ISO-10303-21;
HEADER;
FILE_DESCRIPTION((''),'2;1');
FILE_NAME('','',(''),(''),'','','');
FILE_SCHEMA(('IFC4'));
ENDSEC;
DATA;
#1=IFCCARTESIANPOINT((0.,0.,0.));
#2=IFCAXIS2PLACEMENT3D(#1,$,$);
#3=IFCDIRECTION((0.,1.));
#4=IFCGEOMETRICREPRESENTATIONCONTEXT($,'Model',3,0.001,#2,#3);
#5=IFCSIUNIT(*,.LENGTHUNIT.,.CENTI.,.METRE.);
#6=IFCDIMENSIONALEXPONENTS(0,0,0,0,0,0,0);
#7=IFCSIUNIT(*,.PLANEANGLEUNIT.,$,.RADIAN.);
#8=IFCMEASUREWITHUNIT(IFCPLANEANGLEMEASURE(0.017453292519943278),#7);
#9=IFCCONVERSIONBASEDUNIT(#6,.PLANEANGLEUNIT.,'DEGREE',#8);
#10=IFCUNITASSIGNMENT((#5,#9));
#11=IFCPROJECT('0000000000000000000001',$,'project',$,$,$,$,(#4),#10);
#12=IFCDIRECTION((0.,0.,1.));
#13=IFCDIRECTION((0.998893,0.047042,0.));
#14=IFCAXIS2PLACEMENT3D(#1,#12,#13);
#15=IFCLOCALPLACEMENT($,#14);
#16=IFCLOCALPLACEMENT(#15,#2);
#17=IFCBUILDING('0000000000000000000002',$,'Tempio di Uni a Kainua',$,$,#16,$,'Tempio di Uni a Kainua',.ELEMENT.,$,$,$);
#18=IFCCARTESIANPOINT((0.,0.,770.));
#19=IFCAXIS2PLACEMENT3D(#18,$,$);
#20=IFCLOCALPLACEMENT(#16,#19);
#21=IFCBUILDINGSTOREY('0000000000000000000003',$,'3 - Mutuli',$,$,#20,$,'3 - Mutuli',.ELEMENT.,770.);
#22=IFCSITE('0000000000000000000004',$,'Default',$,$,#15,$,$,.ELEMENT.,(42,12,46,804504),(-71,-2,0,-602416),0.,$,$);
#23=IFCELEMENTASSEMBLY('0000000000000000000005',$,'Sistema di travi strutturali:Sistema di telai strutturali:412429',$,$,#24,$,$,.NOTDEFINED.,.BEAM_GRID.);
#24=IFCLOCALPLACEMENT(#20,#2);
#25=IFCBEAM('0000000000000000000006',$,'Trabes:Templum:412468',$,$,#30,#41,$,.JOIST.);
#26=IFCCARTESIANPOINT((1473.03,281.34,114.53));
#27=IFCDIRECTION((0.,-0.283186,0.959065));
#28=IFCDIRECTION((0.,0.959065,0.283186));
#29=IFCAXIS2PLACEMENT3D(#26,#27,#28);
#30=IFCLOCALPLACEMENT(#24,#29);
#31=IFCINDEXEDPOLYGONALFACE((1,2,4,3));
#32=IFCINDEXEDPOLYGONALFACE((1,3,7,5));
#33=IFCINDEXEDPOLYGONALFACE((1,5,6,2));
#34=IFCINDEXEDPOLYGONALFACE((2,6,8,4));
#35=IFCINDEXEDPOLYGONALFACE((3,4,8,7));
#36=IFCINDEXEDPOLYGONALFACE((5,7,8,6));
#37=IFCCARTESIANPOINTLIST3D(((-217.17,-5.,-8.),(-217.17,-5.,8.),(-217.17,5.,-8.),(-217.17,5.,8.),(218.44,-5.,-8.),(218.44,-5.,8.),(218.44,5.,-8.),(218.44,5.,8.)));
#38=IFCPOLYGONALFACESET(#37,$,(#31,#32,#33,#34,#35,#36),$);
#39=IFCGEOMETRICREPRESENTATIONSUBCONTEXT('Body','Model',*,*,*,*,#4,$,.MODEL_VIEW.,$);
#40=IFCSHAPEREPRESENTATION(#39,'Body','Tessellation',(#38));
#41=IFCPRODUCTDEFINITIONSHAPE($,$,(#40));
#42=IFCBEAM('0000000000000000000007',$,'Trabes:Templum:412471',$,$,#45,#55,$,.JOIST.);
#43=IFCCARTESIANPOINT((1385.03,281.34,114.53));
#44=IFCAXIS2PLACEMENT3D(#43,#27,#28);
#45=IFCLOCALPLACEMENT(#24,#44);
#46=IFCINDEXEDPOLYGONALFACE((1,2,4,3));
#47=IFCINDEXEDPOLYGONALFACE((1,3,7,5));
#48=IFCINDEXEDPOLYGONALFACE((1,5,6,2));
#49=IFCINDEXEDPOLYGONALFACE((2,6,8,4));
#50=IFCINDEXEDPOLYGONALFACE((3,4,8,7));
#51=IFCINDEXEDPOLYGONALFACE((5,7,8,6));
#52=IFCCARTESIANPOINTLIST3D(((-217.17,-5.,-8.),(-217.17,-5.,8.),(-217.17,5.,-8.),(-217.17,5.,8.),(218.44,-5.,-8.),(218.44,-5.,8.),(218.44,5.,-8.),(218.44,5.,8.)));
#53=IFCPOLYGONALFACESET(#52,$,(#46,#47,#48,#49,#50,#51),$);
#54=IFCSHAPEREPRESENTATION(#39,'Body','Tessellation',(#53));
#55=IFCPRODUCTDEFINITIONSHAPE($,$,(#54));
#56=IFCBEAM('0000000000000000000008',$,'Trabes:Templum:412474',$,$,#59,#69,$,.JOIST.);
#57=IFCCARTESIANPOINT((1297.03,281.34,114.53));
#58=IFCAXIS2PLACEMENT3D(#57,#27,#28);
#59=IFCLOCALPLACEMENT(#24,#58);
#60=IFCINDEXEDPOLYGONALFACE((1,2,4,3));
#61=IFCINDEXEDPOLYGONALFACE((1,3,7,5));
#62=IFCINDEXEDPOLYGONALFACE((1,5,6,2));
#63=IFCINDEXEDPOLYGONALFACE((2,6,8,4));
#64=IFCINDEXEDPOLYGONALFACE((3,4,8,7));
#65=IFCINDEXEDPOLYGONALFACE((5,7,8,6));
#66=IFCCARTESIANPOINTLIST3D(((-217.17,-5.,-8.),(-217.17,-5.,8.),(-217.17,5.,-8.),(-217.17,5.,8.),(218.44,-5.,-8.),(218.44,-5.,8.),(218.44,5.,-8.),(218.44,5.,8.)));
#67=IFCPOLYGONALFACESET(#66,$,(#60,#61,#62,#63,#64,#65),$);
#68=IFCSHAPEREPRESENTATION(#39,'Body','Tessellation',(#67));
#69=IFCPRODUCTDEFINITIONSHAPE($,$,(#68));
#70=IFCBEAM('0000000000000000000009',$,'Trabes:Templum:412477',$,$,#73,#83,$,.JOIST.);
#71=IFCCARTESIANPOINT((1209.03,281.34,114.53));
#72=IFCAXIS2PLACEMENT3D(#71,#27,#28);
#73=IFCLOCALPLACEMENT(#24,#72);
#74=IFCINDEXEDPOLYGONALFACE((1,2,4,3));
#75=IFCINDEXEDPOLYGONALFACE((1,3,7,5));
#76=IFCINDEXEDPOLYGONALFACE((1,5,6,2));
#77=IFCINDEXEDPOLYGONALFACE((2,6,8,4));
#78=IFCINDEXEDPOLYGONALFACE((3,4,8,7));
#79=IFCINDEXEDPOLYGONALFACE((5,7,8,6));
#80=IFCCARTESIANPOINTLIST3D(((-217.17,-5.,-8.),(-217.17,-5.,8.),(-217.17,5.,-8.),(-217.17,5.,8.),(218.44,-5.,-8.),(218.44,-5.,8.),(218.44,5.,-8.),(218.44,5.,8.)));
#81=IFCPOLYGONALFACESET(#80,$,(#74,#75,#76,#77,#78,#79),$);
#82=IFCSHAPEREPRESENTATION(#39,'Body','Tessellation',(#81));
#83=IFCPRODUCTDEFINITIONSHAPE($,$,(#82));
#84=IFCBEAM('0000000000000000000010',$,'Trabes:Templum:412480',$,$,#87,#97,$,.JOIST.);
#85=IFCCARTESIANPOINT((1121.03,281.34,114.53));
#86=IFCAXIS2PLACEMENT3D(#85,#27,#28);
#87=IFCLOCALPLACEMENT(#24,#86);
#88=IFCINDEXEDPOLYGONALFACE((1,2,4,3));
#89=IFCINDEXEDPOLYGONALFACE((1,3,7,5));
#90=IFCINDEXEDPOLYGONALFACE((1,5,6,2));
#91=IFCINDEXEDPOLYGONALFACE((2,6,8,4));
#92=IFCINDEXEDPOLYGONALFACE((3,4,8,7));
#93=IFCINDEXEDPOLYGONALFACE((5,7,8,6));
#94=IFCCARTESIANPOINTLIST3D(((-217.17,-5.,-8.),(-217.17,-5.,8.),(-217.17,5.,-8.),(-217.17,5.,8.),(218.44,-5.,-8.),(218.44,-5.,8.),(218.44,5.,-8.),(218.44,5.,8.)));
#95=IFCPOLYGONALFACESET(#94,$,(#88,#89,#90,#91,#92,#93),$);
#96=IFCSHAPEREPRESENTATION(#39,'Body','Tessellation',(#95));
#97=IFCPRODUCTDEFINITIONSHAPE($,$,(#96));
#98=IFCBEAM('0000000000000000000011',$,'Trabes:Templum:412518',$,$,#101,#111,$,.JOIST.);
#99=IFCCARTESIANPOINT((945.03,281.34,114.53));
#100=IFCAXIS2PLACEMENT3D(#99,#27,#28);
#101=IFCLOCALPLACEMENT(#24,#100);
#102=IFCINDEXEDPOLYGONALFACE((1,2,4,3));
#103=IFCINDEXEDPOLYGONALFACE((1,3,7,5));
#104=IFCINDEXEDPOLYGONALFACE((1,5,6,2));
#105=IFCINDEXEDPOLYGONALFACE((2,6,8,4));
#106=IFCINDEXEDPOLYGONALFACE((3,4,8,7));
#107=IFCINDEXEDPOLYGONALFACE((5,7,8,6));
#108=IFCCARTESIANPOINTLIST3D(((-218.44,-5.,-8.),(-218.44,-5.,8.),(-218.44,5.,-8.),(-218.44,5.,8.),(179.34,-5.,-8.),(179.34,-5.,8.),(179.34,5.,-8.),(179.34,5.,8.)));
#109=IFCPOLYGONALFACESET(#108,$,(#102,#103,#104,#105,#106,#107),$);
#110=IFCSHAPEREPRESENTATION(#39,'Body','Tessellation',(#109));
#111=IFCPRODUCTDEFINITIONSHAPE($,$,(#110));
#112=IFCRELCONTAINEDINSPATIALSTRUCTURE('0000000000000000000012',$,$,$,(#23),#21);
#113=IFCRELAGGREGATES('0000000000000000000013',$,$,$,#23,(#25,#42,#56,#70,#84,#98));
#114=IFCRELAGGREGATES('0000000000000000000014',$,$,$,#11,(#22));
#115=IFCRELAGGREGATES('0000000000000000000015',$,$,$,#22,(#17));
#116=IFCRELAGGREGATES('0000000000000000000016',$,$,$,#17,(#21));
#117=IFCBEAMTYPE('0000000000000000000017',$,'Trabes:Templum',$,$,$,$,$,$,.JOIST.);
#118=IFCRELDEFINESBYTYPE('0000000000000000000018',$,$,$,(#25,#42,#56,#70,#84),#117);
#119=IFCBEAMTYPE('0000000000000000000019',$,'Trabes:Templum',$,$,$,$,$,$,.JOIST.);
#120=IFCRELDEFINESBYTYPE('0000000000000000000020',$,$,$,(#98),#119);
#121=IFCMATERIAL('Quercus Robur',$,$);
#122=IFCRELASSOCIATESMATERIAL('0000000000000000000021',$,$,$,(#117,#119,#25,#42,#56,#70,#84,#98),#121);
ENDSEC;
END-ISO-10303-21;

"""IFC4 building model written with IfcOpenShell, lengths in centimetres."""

from ifc_helpers import new_model, entity, si_unit, converted_unit, direction, frame, origin, origin_2d_with_axis, place, context, subcontext, project, spatial, rectangle, extrude, source, transform, mapped, material, material_profile, profile_set, profile_usage, type_object, type_shapes, element, aggregate, save


model = new_model("IFC4")

# Units and contexts
model_context = context("Model", 3, precision=0.001, world=origin(), true_north=direction((0.0, 1.0)))
body_context = subcontext(model_context, "Body", "Model", "MODEL_VIEW")
ifc_project = project(units=[si_unit("LENGTHUNIT", "METRE", prefix="CENTI"), converted_unit("PLANEANGLEUNIT", "DEGREE", entity("IfcPlaneAngleMeasure", 0.017453292519943278), si_unit("PLANEANGLEUNIT", "RADIAN"), dimensions=[0, 0, 0, 0, 0, 0, 0])], contexts=[model_context])

# Site, building, storey
site_placement = place(None, frame((0.0, 0.0, 0.0), z_axis=(0.0, 0.0, 1.0), x_axis=(0.998893, 0.047042, 0.0)))
site = spatial("IfcSite", under=ifc_project, at=site_placement, Name="Default", CompositionType="ELEMENT", RefLatitude=(42, 12, 46, 804504), RefLongitude=(-71, -2, 0, -602416), RefElevation=0.0)
building_placement = place(site_placement, origin())
building = spatial("IfcBuilding", under=site, at=building_placement, Name="Tempio di Uni a Kainua", LongName="Tempio di Uni a Kainua", CompositionType="ELEMENT")
storey_placement = place(building_placement, frame((0.0, 0.0, 770.0)))
storey = spatial("IfcBuildingStorey", under=building, at=storey_placement, Name="3 - Mutuli", LongName="3 - Mutuli", CompositionType="ELEMENT", Elevation=770.0)

# Shared definitions
ifc_material = material(Name="Quercus Robur")

# Element assembly, beams
assembly_placement = place(storey_placement, origin())
assembly = element("IfcElementAssembly", 1, at=assembly_placement, inside=storey, Name="Sistema di travi strutturali:Sistema di telai strutturali:412429", AssemblyPlace="NOTDEFINED", PredefinedType="BEAM_GRID")
ifc_material_profile_1 = material_profile(ifc_material, rectangle(XDim=2875.46, YDim=10.0, at=origin_2d_with_axis()), Name="Templum")
ifc_profile_set_1 = profile_set([ifc_material_profile_1], Name="Templum")
ifc_profile_usage_1 = profile_usage(ifc_profile_set_1, cardinal=2)
beam_type_1 = type_object("IfcBeamType", Name="Trabes:Templum", PredefinedType="JOIST", material=ifc_profile_set_1)
shared_shape_1 = source(origin(), body_context, "Body", "SweptSolid", [
    extrude(rectangle(XDim=435.61, YDim=10.0, at=origin_2d_with_axis()), frame((0.64, 0.0, -8.0)), (0.0, 0.0, 1.0), 16.0),
])
type_shapes(beam_type_1, [shared_shape_1])
beam_1_placement = place(assembly_placement, frame((1473.03, 281.34, 114.53), z_axis=(0.0, -0.283186, 0.959065), x_axis=(0.0, 0.959065, 0.283186)))
beam_1 = element("IfcBeam", 2, at=beam_1_placement, type_object=beam_type_1, material=ifc_profile_usage_1, Name="Trabes:Templum:412468", PredefinedType="JOIST", context=body_context, shape_type="MappedRepresentation", body=[
    mapped(shared_shape_1, transform((0.0, 0.0, 0.0), scale=1.0)),
])
beam_2_placement = place(assembly_placement, frame((1385.03, 281.34, 114.53), z_axis=(0.0, -0.283186, 0.959065), x_axis=(0.0, 0.959065, 0.283186)))
beam_2 = element("IfcBeam", 3, at=beam_2_placement, type_object=beam_type_1, material=ifc_profile_usage_1, Name="Trabes:Templum:412471", PredefinedType="JOIST", context=body_context, shape_type="MappedRepresentation", body=[
    mapped(shared_shape_1, transform((0.0, 0.0, 0.0), scale=1.0)),
])
beam_3_placement = place(assembly_placement, frame((1297.03, 281.34, 114.53), z_axis=(0.0, -0.283186, 0.959065), x_axis=(0.0, 0.959065, 0.283186)))
beam_3 = element("IfcBeam", 4, at=beam_3_placement, type_object=beam_type_1, material=ifc_profile_usage_1, Name="Trabes:Templum:412474", PredefinedType="JOIST", context=body_context, shape_type="MappedRepresentation", body=[
    mapped(shared_shape_1, transform((0.0, 0.0, 0.0), scale=1.0)),
])
beam_4_placement = place(assembly_placement, frame((1209.03, 281.34, 114.53), z_axis=(0.0, -0.283186, 0.959065), x_axis=(0.0, 0.959065, 0.283186)))
beam_4 = element("IfcBeam", 5, at=beam_4_placement, type_object=beam_type_1, material=ifc_profile_usage_1, Name="Trabes:Templum:412477", PredefinedType="JOIST", context=body_context, shape_type="MappedRepresentation", body=[
    mapped(shared_shape_1, transform((0.0, 0.0, 0.0), scale=1.0)),
])
beam_5_placement = place(assembly_placement, frame((1121.03, 281.34, 114.53), z_axis=(0.0, -0.283186, 0.959065), x_axis=(0.0, 0.959065, 0.283186)))
beam_5 = element("IfcBeam", 6, at=beam_5_placement, type_object=beam_type_1, material=ifc_profile_usage_1, Name="Trabes:Templum:412480", PredefinedType="JOIST", context=body_context, shape_type="MappedRepresentation", body=[
    mapped(shared_shape_1, transform((0.0, 0.0, 0.0), scale=1.0)),
])
beam_type_2 = type_object("IfcBeamType", Name="Trabes:Templum", PredefinedType="JOIST", material=ifc_profile_set_1)
shared_shape_2 = source(origin(), body_context, "Body", "SweptSolid", [
    extrude(rectangle(XDim=397.78, YDim=10.0, at=origin_2d_with_axis()), frame((-19.55, 0.0, -8.0)), (0.0, 0.0, 1.0), 16.0),
])
type_shapes(beam_type_2, [shared_shape_2])
beam_6_placement = place(assembly_placement, frame((945.03, 281.34, 114.53), z_axis=(0.0, -0.283186, 0.959065), x_axis=(0.0, 0.959065, 0.283186)))
beam_6 = element("IfcBeam", 7, at=beam_6_placement, type_object=beam_type_2, material=ifc_profile_usage_1, Name="Trabes:Templum:412518", PredefinedType="JOIST", context=body_context, shape_type="MappedRepresentation", body=[
    mapped(shared_shape_2, transform((0.0, 0.0, 0.0), scale=1.0)),
])
aggregate(assembly, [beam_1, beam_2, beam_3, beam_4, beam_5, beam_6])

save(model, "model.ifc")
